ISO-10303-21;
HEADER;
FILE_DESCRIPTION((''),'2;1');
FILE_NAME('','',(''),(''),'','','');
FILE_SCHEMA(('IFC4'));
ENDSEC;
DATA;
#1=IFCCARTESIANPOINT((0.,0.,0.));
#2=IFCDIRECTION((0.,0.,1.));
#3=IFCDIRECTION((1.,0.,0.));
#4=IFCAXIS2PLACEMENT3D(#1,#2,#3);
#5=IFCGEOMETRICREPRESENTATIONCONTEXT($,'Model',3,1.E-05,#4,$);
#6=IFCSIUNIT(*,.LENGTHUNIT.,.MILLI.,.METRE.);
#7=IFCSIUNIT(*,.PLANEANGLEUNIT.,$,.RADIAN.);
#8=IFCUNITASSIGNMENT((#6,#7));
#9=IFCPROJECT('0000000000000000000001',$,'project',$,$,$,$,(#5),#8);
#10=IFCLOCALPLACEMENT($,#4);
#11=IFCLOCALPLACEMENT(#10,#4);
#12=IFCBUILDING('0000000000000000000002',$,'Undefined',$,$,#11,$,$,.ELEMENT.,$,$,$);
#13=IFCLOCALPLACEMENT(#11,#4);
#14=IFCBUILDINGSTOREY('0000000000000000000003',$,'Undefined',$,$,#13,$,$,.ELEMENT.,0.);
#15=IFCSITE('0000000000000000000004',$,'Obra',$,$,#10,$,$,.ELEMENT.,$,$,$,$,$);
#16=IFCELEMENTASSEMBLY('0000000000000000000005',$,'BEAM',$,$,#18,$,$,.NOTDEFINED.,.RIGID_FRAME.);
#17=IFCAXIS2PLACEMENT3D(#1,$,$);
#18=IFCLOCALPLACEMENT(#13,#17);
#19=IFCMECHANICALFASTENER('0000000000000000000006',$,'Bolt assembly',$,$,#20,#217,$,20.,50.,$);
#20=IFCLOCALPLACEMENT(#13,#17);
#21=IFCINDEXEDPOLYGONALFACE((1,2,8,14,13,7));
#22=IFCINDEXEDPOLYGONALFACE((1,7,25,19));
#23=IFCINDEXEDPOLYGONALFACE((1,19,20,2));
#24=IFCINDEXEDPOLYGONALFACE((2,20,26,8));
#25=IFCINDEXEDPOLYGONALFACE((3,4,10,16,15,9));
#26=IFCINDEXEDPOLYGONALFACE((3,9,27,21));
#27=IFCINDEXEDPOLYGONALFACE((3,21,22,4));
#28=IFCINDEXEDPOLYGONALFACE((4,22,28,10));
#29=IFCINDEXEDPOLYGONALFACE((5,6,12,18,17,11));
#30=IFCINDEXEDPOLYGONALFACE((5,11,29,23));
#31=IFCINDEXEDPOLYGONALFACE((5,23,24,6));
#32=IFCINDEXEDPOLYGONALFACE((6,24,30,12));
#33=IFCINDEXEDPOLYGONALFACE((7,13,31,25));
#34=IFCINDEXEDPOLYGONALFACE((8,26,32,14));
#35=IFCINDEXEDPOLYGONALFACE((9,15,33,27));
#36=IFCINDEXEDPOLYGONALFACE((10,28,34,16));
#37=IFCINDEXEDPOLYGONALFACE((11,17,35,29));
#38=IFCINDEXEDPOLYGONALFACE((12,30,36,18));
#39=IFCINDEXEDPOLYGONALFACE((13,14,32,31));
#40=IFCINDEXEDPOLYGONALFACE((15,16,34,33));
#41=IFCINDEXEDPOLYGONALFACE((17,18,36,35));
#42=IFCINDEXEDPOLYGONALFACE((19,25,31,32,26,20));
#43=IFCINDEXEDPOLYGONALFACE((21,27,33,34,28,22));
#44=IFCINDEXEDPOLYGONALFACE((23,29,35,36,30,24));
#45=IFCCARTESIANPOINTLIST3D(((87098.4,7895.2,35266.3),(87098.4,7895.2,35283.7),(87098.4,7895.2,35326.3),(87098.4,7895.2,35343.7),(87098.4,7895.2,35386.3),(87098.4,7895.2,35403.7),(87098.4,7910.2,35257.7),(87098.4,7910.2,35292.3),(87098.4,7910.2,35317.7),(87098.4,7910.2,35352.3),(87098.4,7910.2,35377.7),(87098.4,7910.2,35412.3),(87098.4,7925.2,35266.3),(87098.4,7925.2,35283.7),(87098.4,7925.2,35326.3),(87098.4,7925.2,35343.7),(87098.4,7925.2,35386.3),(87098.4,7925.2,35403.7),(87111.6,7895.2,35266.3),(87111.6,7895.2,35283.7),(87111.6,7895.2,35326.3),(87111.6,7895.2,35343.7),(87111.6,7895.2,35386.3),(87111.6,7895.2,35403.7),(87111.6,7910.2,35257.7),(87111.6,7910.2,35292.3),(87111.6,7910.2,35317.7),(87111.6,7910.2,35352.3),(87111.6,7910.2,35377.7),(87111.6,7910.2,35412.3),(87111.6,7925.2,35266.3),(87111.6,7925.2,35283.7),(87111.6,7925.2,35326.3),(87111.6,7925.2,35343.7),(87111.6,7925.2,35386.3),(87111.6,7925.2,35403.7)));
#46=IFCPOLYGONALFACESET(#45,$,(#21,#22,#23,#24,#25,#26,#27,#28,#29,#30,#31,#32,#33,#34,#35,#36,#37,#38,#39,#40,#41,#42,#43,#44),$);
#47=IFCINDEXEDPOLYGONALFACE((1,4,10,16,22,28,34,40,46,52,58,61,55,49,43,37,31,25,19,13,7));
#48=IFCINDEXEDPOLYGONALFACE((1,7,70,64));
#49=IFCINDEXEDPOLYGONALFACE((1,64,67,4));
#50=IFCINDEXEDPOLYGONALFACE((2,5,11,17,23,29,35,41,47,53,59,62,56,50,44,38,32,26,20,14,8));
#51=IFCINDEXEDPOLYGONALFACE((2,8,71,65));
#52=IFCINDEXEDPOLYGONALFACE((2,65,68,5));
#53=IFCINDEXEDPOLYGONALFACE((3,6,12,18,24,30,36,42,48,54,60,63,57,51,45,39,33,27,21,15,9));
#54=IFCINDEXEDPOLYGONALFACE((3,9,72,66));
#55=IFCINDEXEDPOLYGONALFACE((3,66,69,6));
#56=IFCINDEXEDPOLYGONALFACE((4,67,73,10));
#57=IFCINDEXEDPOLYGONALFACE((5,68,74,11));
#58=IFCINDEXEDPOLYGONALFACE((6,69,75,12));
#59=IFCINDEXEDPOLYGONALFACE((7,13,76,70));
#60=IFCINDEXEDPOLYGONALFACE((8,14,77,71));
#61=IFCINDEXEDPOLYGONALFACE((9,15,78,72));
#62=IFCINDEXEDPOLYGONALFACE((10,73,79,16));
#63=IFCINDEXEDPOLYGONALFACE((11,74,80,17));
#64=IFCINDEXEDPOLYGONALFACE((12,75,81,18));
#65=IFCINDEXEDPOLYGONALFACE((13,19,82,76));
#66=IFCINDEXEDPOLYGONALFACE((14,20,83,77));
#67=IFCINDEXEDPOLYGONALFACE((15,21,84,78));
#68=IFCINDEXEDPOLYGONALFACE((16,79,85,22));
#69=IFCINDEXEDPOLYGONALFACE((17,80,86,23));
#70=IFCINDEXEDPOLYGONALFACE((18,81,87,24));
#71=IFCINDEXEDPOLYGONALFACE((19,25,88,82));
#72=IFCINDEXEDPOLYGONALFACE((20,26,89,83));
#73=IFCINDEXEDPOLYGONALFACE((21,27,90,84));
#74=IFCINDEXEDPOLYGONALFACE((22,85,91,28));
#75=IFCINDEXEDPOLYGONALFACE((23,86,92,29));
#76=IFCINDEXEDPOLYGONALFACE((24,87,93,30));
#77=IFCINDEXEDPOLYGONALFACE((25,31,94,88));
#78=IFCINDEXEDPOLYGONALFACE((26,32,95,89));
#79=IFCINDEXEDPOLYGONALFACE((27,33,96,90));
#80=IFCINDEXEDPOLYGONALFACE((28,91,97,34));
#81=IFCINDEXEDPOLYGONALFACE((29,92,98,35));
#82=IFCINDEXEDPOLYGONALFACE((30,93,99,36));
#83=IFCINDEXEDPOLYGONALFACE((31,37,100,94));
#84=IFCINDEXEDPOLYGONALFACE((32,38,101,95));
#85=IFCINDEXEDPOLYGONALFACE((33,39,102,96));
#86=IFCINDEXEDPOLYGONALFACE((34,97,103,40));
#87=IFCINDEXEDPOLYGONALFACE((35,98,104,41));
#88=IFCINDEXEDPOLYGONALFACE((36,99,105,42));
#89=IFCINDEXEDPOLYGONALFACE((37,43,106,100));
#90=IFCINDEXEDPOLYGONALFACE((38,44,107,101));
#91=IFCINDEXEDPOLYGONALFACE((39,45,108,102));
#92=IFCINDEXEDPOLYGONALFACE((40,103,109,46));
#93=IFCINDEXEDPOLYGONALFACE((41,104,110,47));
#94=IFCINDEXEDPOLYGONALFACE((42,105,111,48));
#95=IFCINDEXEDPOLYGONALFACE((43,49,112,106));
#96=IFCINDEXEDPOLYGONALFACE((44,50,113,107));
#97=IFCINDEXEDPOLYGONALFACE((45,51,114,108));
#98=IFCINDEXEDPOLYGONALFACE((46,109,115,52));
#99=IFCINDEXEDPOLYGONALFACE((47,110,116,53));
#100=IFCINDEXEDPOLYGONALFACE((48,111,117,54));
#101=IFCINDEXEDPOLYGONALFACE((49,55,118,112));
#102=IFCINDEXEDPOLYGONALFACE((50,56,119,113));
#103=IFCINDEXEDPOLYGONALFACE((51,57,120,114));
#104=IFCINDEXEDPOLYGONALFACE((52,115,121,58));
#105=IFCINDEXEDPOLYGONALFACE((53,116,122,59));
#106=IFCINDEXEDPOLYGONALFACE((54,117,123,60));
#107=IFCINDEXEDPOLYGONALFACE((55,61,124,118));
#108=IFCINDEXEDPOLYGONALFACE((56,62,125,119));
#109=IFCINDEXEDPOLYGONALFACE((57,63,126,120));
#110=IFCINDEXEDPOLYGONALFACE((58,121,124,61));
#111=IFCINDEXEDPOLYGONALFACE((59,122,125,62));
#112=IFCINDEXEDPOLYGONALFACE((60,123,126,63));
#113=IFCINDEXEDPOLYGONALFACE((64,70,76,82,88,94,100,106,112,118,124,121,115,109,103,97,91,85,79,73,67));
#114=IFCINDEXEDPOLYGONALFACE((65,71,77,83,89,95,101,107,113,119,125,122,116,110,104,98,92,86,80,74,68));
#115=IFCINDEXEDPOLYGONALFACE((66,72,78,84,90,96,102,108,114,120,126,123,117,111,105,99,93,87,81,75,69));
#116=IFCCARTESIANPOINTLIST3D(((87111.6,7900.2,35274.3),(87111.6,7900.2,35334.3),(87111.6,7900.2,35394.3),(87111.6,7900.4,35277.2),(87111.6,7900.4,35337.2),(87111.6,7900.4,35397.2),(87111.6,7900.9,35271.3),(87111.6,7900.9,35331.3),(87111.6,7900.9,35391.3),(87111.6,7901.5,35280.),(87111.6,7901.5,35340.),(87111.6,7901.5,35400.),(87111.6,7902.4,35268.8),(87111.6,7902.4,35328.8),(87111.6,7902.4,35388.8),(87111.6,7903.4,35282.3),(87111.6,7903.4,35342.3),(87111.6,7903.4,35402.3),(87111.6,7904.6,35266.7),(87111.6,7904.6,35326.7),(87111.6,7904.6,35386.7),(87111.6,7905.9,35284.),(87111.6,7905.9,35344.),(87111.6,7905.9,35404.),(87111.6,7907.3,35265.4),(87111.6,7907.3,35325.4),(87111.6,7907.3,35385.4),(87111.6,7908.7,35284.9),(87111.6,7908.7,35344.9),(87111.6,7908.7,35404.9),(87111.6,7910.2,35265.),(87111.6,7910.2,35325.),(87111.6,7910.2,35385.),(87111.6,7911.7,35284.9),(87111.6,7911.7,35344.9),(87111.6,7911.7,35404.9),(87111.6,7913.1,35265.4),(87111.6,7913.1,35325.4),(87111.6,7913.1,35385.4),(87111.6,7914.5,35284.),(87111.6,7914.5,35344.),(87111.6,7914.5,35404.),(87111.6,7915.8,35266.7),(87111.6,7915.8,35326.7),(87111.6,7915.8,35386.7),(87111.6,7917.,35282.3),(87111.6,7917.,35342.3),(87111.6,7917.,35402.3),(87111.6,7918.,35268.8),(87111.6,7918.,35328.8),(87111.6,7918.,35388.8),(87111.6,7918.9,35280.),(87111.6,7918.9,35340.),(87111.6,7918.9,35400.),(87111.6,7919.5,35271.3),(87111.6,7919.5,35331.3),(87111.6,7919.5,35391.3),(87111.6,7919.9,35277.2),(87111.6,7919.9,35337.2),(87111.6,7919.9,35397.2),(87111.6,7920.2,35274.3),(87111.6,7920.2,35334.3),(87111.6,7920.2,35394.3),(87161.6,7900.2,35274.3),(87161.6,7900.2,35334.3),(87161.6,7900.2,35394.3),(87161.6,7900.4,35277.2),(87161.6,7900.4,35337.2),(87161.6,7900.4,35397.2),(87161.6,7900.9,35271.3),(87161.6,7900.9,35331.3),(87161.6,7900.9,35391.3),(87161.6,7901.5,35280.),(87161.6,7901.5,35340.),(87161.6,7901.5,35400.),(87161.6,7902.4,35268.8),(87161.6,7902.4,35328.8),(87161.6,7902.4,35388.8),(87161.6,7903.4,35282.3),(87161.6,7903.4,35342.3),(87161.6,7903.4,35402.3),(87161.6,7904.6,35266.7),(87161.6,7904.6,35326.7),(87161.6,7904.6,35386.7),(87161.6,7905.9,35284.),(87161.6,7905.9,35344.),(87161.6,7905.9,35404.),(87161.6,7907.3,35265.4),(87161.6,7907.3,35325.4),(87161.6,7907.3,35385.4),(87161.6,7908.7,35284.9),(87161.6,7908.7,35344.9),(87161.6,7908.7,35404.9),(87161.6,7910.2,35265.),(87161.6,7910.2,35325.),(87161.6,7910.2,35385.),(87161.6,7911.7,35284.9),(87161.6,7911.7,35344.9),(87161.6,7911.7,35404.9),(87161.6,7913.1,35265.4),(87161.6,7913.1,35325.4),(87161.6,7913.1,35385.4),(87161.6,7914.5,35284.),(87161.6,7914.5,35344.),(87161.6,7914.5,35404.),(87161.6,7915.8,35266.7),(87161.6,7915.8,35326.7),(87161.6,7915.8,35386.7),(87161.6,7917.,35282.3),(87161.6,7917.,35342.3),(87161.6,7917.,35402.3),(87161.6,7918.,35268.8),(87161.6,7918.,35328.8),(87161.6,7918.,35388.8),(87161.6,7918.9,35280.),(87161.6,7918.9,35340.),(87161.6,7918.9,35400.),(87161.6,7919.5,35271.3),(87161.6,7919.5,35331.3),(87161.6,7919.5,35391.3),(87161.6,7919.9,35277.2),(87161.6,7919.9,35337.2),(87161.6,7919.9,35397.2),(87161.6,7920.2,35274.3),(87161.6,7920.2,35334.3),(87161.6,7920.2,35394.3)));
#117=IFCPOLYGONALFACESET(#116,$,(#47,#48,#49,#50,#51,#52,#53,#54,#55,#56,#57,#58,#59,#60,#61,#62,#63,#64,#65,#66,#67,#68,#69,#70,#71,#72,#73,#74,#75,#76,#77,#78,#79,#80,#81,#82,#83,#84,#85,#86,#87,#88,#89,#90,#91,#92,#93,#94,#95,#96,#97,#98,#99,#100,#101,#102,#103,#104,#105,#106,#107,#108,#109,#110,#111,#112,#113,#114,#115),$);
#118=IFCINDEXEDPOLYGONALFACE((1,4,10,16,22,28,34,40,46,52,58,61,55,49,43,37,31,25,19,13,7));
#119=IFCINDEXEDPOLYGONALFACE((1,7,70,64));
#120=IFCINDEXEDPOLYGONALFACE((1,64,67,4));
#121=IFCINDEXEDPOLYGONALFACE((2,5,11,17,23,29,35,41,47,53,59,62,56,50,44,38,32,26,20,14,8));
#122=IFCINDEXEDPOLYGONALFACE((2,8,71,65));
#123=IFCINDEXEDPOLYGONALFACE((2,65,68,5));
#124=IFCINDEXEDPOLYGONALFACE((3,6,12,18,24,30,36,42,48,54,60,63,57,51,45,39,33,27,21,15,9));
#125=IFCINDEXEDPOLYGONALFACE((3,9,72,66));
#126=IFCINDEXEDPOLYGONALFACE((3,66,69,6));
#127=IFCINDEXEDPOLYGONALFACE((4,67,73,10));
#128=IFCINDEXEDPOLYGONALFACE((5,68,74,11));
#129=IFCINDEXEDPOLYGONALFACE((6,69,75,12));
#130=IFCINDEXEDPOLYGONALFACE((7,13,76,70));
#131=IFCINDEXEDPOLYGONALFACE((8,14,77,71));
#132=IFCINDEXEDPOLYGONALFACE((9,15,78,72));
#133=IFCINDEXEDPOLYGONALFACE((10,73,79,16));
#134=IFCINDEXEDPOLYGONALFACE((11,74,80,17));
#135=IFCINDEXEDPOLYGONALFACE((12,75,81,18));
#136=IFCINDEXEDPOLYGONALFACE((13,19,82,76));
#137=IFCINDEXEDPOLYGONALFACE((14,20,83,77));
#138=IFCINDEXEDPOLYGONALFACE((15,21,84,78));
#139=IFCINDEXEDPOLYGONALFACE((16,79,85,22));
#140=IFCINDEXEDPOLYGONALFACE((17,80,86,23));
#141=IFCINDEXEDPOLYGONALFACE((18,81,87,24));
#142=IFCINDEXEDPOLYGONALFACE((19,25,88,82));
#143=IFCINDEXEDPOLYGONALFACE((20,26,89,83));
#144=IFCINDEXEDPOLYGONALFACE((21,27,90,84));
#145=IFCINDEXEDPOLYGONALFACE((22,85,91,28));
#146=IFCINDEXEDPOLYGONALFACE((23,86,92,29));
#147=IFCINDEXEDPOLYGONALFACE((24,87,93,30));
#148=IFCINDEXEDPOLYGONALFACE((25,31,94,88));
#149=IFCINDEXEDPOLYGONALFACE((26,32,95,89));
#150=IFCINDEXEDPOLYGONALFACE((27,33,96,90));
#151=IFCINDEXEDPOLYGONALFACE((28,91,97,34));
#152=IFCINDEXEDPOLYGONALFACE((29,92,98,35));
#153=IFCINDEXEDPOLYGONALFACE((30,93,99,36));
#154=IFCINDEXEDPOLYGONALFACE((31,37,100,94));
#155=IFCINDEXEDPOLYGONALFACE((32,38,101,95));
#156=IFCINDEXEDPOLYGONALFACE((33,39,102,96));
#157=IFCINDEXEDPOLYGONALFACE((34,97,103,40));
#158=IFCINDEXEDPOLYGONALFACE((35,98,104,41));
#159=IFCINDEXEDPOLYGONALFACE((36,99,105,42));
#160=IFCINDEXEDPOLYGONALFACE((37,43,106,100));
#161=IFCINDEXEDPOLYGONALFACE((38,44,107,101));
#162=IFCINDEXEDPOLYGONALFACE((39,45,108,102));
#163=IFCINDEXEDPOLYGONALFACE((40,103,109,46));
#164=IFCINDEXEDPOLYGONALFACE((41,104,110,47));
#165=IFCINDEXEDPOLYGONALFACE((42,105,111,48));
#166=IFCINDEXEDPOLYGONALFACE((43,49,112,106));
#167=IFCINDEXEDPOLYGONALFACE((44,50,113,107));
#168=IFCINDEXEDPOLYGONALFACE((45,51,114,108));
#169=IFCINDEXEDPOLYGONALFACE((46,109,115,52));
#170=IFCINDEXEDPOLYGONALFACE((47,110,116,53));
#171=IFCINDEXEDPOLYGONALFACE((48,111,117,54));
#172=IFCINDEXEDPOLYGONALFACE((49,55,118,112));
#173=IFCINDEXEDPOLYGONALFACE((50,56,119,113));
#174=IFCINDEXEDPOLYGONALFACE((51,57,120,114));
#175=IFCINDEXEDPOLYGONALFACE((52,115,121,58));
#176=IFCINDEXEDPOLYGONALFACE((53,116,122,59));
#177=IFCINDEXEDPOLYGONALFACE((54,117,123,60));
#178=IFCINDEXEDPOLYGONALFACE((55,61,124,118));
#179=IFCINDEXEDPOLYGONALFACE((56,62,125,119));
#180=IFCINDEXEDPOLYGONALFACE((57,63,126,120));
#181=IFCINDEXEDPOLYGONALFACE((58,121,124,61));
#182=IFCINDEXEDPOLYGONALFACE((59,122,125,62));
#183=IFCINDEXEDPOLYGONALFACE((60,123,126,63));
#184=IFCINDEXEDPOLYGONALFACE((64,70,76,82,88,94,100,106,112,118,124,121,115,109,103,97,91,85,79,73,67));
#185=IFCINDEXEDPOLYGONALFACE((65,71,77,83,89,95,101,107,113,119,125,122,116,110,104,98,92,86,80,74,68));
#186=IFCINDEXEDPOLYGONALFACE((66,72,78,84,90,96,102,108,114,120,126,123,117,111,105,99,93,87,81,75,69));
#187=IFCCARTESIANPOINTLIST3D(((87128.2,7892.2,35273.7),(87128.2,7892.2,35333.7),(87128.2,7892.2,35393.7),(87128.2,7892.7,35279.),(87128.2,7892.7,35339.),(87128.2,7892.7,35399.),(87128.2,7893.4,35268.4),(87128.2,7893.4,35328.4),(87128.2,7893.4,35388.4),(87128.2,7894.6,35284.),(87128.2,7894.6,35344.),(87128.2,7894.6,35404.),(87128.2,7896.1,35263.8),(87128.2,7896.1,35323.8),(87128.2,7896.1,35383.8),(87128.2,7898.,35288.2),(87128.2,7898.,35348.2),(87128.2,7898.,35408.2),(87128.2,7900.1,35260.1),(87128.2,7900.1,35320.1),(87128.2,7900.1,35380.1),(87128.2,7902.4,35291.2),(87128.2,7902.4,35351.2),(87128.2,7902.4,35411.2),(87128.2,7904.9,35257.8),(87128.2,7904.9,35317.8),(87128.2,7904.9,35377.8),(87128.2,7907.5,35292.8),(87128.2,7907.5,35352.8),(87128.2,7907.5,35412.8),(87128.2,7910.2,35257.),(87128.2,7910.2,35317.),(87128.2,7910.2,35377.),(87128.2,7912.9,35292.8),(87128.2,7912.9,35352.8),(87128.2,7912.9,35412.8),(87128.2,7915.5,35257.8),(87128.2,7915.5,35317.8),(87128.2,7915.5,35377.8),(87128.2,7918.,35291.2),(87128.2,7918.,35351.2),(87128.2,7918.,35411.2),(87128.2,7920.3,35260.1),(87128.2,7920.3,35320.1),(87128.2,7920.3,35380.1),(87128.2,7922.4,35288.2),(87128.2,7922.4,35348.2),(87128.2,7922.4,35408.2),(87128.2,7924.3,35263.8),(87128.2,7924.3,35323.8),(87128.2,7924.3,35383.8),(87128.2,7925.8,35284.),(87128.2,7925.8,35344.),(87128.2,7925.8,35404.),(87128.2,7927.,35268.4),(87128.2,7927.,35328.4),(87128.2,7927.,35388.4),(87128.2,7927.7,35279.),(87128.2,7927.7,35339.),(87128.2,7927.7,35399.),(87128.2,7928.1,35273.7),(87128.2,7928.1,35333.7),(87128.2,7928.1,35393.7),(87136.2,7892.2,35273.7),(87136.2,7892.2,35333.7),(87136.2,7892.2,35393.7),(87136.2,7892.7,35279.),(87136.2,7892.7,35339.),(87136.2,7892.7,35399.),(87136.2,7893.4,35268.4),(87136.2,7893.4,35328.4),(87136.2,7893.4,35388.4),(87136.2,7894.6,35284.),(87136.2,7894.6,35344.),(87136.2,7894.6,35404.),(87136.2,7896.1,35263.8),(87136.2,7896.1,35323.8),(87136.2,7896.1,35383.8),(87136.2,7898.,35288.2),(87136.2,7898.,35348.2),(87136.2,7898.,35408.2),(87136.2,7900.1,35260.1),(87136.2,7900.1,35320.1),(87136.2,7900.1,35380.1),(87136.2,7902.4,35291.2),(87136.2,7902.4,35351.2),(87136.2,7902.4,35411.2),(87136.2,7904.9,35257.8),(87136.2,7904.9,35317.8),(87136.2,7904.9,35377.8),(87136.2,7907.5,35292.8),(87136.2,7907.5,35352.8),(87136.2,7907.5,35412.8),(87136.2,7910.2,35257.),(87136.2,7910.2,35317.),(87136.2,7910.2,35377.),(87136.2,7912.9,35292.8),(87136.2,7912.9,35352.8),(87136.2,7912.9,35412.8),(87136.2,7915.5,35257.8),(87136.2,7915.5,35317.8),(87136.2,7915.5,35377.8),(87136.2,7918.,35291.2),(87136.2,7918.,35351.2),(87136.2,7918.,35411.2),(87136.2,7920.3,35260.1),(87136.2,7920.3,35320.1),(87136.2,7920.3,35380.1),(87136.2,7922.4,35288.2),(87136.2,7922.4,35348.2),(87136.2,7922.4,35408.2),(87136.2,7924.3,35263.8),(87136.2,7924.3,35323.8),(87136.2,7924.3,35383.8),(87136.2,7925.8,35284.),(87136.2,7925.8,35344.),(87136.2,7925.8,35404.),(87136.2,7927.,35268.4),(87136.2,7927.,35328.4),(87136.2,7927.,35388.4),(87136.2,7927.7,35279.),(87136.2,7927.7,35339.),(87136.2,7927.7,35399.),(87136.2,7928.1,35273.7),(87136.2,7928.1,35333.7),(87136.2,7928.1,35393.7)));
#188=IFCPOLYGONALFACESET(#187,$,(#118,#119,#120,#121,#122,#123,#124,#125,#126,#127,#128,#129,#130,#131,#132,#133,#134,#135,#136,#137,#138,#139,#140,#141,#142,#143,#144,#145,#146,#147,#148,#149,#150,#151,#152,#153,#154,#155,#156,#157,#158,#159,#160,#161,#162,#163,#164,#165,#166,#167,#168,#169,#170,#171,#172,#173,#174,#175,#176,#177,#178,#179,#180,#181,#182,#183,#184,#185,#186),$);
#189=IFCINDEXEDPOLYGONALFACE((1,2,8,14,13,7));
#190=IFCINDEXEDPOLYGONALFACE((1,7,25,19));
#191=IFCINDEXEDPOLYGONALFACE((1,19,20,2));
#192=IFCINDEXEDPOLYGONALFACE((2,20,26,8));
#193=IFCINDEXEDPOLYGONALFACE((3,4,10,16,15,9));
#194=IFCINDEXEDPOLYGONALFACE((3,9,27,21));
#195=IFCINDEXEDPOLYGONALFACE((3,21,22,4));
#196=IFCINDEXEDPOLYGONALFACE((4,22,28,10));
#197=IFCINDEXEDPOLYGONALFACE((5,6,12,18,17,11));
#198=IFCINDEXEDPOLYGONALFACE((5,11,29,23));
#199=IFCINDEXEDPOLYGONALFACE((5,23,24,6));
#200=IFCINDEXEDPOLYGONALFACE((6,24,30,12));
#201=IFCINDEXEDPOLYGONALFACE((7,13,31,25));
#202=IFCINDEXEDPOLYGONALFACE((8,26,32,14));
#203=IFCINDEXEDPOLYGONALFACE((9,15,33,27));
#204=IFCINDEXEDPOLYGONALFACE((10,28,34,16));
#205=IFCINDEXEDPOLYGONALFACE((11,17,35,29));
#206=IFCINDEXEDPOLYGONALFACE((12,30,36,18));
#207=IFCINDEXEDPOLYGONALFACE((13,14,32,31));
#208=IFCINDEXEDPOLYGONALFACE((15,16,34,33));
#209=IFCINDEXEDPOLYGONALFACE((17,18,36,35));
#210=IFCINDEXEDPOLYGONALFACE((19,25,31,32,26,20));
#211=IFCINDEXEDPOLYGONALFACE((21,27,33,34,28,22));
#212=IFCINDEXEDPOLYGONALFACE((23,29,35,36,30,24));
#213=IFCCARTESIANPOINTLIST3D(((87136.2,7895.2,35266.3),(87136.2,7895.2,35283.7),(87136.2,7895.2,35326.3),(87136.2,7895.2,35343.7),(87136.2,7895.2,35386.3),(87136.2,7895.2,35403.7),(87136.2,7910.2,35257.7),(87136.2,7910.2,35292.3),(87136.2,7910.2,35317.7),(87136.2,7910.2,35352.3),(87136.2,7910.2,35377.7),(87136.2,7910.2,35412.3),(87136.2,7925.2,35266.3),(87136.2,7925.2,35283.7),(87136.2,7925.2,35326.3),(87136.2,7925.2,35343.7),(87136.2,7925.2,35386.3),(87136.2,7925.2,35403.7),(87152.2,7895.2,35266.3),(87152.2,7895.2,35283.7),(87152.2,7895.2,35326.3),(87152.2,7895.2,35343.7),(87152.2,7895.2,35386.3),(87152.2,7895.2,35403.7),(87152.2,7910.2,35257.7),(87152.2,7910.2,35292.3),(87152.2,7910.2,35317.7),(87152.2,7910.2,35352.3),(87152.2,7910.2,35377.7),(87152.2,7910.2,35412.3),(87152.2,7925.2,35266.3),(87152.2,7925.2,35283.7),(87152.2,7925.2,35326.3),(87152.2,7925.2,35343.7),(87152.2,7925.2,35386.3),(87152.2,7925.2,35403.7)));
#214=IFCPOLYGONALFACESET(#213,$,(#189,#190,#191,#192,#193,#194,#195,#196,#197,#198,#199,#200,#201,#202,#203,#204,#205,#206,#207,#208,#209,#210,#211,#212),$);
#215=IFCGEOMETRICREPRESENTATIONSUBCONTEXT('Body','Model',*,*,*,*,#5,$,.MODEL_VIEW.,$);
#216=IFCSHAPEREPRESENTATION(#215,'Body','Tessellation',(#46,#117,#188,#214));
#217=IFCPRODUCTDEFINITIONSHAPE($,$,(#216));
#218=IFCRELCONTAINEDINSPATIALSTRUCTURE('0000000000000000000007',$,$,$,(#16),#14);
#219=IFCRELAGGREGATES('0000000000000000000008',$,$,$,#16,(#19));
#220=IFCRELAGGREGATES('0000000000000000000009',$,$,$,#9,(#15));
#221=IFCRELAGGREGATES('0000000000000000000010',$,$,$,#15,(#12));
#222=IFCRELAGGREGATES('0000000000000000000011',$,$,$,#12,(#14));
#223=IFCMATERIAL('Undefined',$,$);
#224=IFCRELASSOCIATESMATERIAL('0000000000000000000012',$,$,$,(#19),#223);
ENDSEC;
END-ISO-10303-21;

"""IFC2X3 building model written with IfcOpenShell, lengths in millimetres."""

from ifc_helpers import new_model, si_unit, frame, origin_with_axes, origin_2d_with_axis, place, context, subcontext, project, spatial, polyline, circle, outline, extrude, source, transform, mapped, material, element, aggregate, save


model = new_model("IFC2X3")

# Units and contexts
model_context = context("Model", 3, precision=1e-05, world=origin_with_axes())
body_context = subcontext(model_context, "Body", "Model", "MODEL_VIEW")
ifc_project = project(units=[si_unit("LENGTHUNIT", "METRE", prefix="MILLI"), si_unit("PLANEANGLEUNIT", "RADIAN")], contexts=[model_context])

# Site, building, storey
site_placement = place(None, origin_with_axes())
site = spatial("IfcSite", under=ifc_project, at=site_placement, Name="Obra", CompositionType="ELEMENT")
building_placement = place(site_placement, origin_with_axes())
building = spatial("IfcBuilding", under=site, at=building_placement, Name="Undefined", CompositionType="ELEMENT")
storey_placement = place(building_placement, origin_with_axes())
storey = spatial("IfcBuildingStorey", under=building, at=storey_placement, Name="Undefined", CompositionType="ELEMENT", Elevation=0.0)

# Shared definitions
ifc_material_1 = material(Name="Undefined")

# Element assembly, mechanical fastener
assembly_1_placement = place(storey_placement, origin_with_axes())
assembly_1 = element("IfcElementAssembly", 1, at=assembly_1_placement, inside=storey, Name="BEAM", AssemblyPlace="NOTDEFINED", PredefinedType="RIGID_FRAME")
shared_shape_1 = source(origin_with_axes(), body_context, "Body", "SweptSolid", [
    extrude(outline(polyline([(17.3, 0.0), (8.7, 15.0), (-8.7, 15.0), (-17.3, 0.0), (-8.7, -15.0), (8.7, -15.0), (17.3, 0.0)])), frame((0.0, -26.5, 0.0), z_axis=(0.0, 1.0, 0.0), x_axis=(1.0, 0.0, 0.0)), (0.0, 0.0, 1.0), 13.2),
    extrude(circle(Radius=10.0, at=origin_2d_with_axis()), frame((0.0, -13.3, 0.0), z_axis=(0.0, 1.0, 0.0), x_axis=(1.0, 0.0, 0.0)), (0.0, 0.0, 1.0), 50.0),
    extrude(circle(Radius=18.0, at=origin_2d_with_axis()), frame((0.0, 3.3, 0.0), z_axis=(0.0, 1.0, 0.0), x_axis=(1.0, 0.0, 0.0)), (0.0, 0.0, 1.0), 8.0),
    extrude(outline(polyline([(17.3, 0.0), (8.7, 15.0), (-8.7, 15.0), (-17.3, 0.0), (-8.7, -15.0), (8.7, -15.0), (17.3, 0.0)])), frame((0.0, 11.3, 0.0), z_axis=(0.0, 1.0, 0.0), x_axis=(1.0, 0.0, 0.0)), (0.0, 0.0, 1.0), 16.0),
])
mechanical_fastener_1_placement = place(assembly_1_placement, frame((87124.9, 7960.2, 35435.0), z_axis=(0.0, -1.0, 0.0), x_axis=(0.0, 0.0, -1.0)))
mechanical_fastener_1 = element("IfcMechanicalFastener", 2, at=mechanical_fastener_1_placement, material=ifc_material_1, Name="Bolt assembly", NominalDiameter=20.0, NominalLength=50.0, context=body_context, shape_type="MappedRepresentation", body=[
    mapped(shared_shape_1, transform((40.0, 0.0, 50.0))),
    mapped(shared_shape_1, transform((100.0, 0.0, 50.0))),
    mapped(shared_shape_1, transform((160.0, 0.0, 50.0))),
])
aggregate(assembly_1, [mechanical_fastener_1])

save(model, "model.ifc")
